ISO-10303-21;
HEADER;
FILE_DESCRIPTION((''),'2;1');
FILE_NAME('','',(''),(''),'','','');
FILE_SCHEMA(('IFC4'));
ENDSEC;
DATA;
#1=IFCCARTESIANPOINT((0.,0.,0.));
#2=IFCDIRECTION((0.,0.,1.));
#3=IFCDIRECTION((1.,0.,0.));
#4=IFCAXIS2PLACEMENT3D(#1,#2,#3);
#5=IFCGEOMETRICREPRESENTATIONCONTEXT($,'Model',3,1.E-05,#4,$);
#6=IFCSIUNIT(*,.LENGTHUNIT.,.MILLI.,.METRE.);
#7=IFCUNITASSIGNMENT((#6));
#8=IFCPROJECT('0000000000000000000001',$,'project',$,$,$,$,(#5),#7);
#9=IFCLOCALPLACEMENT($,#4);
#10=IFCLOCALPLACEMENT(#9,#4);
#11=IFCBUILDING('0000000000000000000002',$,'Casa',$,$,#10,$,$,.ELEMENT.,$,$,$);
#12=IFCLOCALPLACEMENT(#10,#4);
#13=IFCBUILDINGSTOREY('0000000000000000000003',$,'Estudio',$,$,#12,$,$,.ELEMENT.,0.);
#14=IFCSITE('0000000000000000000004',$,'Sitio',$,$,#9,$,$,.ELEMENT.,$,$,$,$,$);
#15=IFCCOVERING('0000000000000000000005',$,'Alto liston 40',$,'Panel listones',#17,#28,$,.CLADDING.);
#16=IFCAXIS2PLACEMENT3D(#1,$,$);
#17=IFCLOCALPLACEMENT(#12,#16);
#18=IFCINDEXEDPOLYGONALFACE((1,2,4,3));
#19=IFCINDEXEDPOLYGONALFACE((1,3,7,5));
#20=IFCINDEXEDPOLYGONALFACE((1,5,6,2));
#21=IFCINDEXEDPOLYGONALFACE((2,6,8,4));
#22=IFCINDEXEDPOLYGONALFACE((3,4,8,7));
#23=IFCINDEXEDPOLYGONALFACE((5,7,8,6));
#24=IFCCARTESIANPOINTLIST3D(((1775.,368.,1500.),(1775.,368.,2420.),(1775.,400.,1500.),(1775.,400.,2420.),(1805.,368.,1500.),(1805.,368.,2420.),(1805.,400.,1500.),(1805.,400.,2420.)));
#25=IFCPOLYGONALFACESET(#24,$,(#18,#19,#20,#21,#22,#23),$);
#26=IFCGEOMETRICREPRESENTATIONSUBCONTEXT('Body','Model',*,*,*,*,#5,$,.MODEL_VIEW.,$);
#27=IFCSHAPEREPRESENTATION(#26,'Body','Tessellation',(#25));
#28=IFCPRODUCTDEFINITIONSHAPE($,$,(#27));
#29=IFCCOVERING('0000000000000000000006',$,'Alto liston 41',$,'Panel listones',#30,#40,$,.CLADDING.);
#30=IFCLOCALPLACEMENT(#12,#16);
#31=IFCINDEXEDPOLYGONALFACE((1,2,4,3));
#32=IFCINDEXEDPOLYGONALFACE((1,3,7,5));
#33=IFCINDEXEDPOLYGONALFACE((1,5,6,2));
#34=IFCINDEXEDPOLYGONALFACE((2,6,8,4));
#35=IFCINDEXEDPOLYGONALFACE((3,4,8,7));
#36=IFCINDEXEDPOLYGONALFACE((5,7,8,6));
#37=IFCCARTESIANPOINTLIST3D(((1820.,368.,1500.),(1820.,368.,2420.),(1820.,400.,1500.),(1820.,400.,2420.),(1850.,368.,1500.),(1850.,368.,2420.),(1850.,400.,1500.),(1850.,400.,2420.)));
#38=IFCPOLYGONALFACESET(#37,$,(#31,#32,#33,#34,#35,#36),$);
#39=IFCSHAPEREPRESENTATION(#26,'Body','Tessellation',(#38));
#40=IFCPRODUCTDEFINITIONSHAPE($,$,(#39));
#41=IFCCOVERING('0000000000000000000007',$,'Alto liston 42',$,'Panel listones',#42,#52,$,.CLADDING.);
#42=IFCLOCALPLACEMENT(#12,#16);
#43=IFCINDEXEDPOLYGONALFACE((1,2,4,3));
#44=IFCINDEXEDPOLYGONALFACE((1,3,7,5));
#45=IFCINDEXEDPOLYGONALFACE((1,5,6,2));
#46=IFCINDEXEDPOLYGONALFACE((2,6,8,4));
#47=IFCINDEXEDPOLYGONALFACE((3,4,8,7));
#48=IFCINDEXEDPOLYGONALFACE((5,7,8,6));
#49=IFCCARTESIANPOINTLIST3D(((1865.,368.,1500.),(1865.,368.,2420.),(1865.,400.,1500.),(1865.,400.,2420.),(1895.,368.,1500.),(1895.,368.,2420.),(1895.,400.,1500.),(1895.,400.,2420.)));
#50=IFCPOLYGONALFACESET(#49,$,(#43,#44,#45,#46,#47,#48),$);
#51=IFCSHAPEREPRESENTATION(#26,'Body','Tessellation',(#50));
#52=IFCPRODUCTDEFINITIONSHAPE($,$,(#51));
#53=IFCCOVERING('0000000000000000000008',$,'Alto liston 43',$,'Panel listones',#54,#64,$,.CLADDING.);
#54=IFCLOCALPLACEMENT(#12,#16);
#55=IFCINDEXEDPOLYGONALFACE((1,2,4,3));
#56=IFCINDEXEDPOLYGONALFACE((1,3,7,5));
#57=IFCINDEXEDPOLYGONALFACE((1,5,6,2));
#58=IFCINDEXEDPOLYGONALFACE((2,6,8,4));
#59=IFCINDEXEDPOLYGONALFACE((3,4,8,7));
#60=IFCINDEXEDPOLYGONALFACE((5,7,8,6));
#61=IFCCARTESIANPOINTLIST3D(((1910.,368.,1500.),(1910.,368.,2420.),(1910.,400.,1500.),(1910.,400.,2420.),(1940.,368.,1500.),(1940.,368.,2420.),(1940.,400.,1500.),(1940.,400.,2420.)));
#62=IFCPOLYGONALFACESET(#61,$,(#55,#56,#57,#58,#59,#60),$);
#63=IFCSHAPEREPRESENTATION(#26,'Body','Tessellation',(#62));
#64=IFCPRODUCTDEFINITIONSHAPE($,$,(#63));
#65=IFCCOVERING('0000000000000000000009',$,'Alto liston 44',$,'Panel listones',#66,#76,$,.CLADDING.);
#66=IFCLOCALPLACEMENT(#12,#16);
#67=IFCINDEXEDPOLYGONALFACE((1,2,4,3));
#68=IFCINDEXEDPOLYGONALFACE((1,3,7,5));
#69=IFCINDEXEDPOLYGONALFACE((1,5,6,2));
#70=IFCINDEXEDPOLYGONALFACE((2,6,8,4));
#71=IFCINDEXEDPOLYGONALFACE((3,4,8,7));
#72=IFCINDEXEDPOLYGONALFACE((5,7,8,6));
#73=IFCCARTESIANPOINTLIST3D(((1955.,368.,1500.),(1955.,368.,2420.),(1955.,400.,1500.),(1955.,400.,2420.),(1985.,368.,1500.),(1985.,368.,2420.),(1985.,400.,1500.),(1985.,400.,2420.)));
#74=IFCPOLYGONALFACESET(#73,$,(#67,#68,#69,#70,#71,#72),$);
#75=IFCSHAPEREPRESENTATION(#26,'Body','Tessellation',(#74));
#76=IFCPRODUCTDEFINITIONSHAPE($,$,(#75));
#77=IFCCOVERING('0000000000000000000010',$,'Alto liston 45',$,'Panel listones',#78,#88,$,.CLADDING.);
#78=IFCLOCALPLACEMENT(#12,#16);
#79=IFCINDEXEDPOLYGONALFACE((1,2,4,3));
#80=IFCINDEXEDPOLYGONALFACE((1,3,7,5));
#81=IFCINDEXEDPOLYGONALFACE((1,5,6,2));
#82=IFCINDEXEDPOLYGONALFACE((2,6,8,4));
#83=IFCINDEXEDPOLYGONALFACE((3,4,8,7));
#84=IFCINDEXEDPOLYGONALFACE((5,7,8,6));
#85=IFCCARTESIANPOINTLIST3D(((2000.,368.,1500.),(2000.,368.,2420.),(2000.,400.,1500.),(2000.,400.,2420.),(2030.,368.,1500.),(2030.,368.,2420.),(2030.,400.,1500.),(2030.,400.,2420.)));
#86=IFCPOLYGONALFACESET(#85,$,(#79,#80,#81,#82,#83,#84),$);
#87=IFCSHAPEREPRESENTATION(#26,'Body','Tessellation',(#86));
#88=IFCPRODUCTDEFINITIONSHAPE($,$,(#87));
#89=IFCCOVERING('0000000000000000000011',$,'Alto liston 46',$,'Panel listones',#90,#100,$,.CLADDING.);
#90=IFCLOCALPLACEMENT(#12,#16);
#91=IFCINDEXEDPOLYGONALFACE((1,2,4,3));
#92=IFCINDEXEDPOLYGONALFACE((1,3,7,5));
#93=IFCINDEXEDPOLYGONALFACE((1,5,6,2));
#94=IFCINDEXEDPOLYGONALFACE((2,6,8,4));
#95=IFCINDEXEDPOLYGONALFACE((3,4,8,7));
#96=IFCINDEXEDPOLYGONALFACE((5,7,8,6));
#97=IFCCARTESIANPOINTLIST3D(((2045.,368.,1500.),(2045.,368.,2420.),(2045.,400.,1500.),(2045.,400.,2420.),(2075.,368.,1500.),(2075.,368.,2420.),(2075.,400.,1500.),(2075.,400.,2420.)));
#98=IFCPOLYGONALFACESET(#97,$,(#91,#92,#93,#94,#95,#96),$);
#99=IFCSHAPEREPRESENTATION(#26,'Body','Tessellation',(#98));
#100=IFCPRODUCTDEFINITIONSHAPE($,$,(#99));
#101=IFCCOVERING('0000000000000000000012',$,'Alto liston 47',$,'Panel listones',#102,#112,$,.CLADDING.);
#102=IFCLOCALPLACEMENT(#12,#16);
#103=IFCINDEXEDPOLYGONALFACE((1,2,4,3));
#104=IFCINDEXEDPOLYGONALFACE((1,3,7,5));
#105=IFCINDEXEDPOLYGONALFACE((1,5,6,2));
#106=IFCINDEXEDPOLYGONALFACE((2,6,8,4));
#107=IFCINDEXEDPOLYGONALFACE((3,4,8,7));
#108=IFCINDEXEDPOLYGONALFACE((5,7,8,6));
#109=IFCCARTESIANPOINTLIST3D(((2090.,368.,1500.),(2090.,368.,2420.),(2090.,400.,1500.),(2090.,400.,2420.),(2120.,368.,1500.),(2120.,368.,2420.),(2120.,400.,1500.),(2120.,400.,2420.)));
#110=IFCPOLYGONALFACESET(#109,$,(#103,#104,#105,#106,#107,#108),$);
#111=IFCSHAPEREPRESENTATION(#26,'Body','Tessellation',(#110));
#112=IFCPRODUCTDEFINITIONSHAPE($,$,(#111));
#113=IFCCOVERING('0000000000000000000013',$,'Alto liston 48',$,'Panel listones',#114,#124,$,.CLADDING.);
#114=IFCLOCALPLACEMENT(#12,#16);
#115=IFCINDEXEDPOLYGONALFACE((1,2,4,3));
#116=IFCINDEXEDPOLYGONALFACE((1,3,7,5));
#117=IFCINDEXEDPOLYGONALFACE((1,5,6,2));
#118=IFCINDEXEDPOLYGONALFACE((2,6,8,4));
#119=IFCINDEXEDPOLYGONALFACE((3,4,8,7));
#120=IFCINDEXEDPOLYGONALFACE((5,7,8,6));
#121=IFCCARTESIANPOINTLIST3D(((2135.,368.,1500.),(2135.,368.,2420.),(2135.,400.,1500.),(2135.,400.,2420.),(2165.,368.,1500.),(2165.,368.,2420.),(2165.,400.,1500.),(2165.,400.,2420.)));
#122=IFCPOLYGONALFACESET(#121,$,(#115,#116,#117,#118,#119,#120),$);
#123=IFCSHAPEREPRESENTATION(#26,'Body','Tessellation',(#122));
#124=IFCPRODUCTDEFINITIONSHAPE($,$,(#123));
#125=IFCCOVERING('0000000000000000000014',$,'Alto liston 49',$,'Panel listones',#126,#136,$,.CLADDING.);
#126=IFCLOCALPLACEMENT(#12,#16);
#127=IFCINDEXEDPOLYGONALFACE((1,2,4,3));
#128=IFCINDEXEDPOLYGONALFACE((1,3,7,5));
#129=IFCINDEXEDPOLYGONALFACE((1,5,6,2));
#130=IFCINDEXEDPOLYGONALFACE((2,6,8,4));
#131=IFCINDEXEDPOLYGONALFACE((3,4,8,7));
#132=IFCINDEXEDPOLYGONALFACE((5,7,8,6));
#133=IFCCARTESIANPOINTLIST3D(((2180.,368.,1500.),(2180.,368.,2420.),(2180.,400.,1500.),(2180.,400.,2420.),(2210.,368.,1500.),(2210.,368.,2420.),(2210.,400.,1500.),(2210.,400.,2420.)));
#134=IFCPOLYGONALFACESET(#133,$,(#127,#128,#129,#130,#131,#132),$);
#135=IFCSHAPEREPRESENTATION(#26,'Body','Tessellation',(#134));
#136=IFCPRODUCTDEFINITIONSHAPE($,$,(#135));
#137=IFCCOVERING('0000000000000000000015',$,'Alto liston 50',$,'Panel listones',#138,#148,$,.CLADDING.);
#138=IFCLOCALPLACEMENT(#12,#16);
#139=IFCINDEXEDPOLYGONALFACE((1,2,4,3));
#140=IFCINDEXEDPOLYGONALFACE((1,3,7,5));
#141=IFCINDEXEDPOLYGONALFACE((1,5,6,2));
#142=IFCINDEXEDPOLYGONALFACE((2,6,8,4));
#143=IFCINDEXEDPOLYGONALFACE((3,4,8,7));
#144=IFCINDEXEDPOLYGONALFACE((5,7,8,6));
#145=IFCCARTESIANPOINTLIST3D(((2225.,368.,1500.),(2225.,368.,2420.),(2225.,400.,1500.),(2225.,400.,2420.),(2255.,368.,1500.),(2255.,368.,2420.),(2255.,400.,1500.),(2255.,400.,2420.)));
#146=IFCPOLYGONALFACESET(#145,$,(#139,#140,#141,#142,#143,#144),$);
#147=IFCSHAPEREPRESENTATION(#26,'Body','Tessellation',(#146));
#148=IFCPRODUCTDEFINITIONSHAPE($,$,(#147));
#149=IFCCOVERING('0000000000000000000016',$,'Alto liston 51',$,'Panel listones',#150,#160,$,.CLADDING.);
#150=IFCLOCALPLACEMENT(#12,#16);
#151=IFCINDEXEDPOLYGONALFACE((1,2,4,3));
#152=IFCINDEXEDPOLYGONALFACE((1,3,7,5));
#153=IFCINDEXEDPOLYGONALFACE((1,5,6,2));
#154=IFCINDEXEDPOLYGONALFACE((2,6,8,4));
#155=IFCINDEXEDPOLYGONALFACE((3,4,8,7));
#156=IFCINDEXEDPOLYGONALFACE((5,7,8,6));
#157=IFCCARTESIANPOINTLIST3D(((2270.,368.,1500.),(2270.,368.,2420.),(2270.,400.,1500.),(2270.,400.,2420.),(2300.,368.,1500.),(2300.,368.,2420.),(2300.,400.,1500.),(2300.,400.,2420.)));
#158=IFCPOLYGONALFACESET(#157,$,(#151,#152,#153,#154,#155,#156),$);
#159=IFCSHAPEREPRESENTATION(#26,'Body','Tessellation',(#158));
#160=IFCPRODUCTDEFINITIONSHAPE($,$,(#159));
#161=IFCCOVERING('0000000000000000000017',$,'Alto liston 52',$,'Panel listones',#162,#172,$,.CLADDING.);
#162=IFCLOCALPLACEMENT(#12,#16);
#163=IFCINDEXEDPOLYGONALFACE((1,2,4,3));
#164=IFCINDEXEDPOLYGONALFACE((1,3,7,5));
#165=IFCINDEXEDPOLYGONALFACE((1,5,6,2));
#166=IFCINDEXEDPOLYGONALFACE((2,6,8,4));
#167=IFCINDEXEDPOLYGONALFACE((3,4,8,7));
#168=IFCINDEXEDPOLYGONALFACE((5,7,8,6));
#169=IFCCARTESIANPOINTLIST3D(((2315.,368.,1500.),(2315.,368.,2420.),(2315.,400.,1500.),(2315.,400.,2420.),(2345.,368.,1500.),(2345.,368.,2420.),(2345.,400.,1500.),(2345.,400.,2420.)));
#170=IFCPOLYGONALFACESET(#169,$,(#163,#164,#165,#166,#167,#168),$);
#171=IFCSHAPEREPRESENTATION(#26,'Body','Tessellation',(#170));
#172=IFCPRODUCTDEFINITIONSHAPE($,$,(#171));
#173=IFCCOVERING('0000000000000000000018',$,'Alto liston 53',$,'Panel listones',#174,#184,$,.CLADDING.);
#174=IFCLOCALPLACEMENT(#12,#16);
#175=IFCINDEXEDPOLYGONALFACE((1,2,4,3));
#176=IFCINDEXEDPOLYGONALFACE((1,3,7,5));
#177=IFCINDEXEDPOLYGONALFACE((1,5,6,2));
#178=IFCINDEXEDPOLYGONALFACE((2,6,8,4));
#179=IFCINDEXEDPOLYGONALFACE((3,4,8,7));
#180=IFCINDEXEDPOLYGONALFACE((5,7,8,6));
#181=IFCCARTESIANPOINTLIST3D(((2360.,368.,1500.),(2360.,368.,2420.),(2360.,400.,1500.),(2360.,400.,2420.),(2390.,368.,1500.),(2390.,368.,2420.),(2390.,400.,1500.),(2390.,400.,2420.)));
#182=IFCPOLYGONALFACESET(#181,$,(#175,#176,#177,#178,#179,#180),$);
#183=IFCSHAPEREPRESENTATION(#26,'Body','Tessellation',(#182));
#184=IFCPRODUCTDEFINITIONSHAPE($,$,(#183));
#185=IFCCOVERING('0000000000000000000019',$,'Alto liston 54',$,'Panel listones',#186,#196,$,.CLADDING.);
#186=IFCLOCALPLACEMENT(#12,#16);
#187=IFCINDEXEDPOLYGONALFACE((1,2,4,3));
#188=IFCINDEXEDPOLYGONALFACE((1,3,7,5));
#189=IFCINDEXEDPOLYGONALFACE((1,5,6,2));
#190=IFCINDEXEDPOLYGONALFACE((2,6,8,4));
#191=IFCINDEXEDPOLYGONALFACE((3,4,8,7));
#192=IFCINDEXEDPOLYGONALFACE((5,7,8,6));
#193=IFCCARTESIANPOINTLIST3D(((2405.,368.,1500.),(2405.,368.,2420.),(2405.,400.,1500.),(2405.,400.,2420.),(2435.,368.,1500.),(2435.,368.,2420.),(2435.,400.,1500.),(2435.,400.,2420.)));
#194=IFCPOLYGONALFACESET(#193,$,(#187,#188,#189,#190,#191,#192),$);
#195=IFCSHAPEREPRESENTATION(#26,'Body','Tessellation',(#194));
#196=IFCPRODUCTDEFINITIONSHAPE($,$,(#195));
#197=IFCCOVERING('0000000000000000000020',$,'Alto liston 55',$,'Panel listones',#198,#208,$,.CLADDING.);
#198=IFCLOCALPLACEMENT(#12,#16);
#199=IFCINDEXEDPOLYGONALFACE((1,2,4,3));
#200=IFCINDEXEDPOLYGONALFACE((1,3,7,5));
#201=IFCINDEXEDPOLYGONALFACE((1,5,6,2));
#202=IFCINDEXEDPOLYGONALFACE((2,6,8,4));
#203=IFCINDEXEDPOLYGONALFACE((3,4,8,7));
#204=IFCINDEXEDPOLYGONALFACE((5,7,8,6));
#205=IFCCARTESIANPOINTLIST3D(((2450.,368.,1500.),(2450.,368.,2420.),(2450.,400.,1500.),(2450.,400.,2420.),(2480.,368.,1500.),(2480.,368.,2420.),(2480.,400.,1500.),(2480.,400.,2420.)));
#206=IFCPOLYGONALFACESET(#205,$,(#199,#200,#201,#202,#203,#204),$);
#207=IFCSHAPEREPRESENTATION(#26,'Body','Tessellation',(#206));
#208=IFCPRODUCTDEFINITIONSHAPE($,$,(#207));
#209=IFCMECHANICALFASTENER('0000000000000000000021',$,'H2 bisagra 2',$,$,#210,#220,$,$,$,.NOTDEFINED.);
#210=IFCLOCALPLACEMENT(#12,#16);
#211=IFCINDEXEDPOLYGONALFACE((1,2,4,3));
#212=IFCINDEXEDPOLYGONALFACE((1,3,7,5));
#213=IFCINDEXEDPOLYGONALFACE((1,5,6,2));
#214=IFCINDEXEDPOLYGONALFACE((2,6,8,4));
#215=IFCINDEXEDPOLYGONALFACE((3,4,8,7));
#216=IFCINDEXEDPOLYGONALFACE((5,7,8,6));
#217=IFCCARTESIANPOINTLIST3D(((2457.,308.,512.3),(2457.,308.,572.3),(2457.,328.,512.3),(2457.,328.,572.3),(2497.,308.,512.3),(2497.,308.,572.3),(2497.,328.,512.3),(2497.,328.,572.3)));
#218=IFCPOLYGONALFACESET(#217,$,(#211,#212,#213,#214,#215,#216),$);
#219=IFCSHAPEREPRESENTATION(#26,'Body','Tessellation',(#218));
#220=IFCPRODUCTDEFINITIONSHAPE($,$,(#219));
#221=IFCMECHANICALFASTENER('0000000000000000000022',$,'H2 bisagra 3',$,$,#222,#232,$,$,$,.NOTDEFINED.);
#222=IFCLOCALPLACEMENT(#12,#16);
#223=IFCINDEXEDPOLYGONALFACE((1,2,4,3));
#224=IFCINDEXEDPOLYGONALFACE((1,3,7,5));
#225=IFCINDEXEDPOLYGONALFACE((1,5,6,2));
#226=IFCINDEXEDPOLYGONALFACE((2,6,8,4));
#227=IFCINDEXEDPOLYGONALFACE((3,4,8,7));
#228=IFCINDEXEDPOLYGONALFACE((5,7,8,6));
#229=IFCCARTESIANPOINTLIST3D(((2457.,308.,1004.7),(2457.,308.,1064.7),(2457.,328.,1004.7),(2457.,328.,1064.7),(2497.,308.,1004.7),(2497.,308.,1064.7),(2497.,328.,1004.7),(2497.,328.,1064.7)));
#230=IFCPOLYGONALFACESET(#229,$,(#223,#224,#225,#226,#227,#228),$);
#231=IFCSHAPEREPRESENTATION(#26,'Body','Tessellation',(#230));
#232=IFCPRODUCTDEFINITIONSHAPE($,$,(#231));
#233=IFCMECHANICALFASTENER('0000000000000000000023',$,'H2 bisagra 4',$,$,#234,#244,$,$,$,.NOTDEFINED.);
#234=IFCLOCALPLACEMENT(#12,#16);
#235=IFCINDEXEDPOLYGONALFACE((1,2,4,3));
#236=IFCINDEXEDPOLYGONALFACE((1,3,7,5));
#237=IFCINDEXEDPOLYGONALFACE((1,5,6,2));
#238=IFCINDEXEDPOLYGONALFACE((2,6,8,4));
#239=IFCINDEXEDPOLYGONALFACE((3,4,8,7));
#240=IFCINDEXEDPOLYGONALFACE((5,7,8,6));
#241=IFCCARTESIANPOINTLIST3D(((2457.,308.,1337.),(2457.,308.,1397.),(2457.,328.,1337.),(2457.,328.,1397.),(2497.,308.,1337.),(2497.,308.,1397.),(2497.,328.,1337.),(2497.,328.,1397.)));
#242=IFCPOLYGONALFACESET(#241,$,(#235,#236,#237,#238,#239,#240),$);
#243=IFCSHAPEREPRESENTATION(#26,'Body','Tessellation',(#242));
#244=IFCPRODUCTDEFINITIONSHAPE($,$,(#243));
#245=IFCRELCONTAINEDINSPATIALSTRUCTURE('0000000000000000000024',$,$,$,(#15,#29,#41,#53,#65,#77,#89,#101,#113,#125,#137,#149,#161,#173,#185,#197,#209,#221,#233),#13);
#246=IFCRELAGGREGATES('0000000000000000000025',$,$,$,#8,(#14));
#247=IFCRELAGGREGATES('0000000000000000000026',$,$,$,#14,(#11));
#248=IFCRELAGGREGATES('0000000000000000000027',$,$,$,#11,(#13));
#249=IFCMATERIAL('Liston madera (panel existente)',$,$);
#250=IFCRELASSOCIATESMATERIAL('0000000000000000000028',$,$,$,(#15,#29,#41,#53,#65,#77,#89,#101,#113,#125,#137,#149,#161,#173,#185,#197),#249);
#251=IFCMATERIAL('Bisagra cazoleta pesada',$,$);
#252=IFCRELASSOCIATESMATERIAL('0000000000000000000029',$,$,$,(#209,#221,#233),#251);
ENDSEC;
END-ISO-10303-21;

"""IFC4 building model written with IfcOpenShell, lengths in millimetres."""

from ifc_helpers import new_model, si_unit, frame, frame_2d, origin_with_axes, place, context, subcontext, project, spatial, rectangle, extrude, material, element, save


model = new_model("IFC4")

# Units and contexts
model_context = context("Model", 3, precision=1e-05, world=origin_with_axes())
body_context = subcontext(model_context, "Body", "Model", "MODEL_VIEW")
ifc_project = project(units=[si_unit("LENGTHUNIT", "METRE", prefix="MILLI")], contexts=[model_context])

# Site, building, storey
site_placement = place(None, origin_with_axes())
site = spatial("IfcSite", under=ifc_project, at=site_placement, Name="Sitio", CompositionType="ELEMENT")
building_placement = place(site_placement, origin_with_axes())
building = spatial("IfcBuilding", under=site, at=building_placement, Name="Casa", CompositionType="ELEMENT")
storey_placement = place(building_placement, origin_with_axes())
storey = spatial("IfcBuildingStorey", under=building, at=storey_placement, Name="Estudio", CompositionType="ELEMENT", Elevation=0.0)

# Coverings
ifc_material_1 = material(Name="Liston madera (panel existente)")
for number, where, z_axis, x_axis, name in (
    (1, (1775.0, 368.0, 1500.0), (0.0, 0.0, 1.0), (1.0, 0.0, 0.0), "Alto liston 40"),
    (2, (1820.0, 368.0, 1500.0), (0.0, 0.0, 1.0), (1.0, 0.0, 0.0), "Alto liston 41"),
    (3, (1865.0, 368.0, 1500.0), (0.0, 0.0, 1.0), (1.0, 0.0, 0.0), "Alto liston 42"),
    (4, (1910.0, 368.0, 1500.0), (0.0, 0.0, 1.0), (1.0, 0.0, 0.0), "Alto liston 43"),
    (5, (1955.0, 368.0, 1500.0), (0.0, 0.0, 1.0), (1.0, 0.0, 0.0), "Alto liston 44"),
    (6, (2000.0, 368.0, 1500.0), (0.0, 0.0, 1.0), (1.0, 0.0, 0.0), "Alto liston 45"),
    (7, (2045.0, 368.0, 1500.0), (0.0, 0.0, 1.0), (1.0, 0.0, 0.0), "Alto liston 46"),
    (8, (2090.0, 368.0, 1500.0), (0.0, 0.0, 1.0), (1.0, 0.0, 0.0), "Alto liston 47"),
    (9, (2135.0, 368.0, 1500.0), (0.0, 0.0, 1.0), (1.0, 0.0, 0.0), "Alto liston 48"),
    (10, (2180.0, 368.0, 1500.0), (0.0, 0.0, 1.0), (1.0, 0.0, 0.0), "Alto liston 49"),
    (11, (2225.0, 368.0, 1500.0), (0.0, 0.0, 1.0), (1.0, 0.0, 0.0), "Alto liston 50"),
    (12, (2270.0, 368.0, 1500.0), (0.0, 0.0, 1.0), (1.0, 0.0, 0.0), "Alto liston 51"),
    (13, (2315.0, 368.0, 1500.0), (0.0, 0.0, 1.0), (1.0, 0.0, 0.0), "Alto liston 52"),
    (14, (2360.0, 368.0, 1500.0), (0.0, 0.0, 1.0), (1.0, 0.0, 0.0), "Alto liston 53"),
    (15, (2405.0, 368.0, 1500.0), (0.0, 0.0, 1.0), (1.0, 0.0, 0.0), "Alto liston 54"),
    (16, (2450.0, 368.0, 1500.0), (0.0, 0.0, 1.0), (1.0, 0.0, 0.0), "Alto liston 55"),
):
    element("IfcCovering", number, at=place(storey_placement, frame(where, z_axis=z_axis, x_axis=x_axis)), inside=storey, material=ifc_material_1, Name=name, ObjectType="Panel listones", PredefinedType="CLADDING", context=body_context, shape_type="SweptSolid", body=[
        extrude(rectangle(XDim=30.0, YDim=32.0, at=frame_2d((15.0, 16.0))), origin_with_axes(), (0.0, 0.0, 1.0), 920.0),
    ])

# Mechanical fasteners
ifc_material_2 = material(Name="Bisagra cazoleta pesada")
for number, where, z_axis, x_axis, name in (
    (17, (2457.0, 308.0, 512.3), (0.0, 0.0, 1.0), (1.0, 0.0, 0.0), "H2 bisagra 2"),
    (18, (2457.0, 308.0, 1004.7), (0.0, 0.0, 1.0), (1.0, 0.0, 0.0), "H2 bisagra 3"),
    (19, (2457.0, 308.0, 1337.0), (0.0, 0.0, 1.0), (1.0, 0.0, 0.0), "H2 bisagra 4"),
):
    element("IfcMechanicalFastener", number, at=place(storey_placement, frame(where, z_axis=z_axis, x_axis=x_axis)), inside=storey, material=ifc_material_2, Name=name, PredefinedType="NOTDEFINED", context=body_context, shape_type="SweptSolid", body=[
        extrude(rectangle(XDim=40.0, YDim=20.0, at=frame_2d((20.0, 10.0))), origin_with_axes(), (0.0, 0.0, 1.0), 60.0),
    ])

save(model, "model.ifc")
